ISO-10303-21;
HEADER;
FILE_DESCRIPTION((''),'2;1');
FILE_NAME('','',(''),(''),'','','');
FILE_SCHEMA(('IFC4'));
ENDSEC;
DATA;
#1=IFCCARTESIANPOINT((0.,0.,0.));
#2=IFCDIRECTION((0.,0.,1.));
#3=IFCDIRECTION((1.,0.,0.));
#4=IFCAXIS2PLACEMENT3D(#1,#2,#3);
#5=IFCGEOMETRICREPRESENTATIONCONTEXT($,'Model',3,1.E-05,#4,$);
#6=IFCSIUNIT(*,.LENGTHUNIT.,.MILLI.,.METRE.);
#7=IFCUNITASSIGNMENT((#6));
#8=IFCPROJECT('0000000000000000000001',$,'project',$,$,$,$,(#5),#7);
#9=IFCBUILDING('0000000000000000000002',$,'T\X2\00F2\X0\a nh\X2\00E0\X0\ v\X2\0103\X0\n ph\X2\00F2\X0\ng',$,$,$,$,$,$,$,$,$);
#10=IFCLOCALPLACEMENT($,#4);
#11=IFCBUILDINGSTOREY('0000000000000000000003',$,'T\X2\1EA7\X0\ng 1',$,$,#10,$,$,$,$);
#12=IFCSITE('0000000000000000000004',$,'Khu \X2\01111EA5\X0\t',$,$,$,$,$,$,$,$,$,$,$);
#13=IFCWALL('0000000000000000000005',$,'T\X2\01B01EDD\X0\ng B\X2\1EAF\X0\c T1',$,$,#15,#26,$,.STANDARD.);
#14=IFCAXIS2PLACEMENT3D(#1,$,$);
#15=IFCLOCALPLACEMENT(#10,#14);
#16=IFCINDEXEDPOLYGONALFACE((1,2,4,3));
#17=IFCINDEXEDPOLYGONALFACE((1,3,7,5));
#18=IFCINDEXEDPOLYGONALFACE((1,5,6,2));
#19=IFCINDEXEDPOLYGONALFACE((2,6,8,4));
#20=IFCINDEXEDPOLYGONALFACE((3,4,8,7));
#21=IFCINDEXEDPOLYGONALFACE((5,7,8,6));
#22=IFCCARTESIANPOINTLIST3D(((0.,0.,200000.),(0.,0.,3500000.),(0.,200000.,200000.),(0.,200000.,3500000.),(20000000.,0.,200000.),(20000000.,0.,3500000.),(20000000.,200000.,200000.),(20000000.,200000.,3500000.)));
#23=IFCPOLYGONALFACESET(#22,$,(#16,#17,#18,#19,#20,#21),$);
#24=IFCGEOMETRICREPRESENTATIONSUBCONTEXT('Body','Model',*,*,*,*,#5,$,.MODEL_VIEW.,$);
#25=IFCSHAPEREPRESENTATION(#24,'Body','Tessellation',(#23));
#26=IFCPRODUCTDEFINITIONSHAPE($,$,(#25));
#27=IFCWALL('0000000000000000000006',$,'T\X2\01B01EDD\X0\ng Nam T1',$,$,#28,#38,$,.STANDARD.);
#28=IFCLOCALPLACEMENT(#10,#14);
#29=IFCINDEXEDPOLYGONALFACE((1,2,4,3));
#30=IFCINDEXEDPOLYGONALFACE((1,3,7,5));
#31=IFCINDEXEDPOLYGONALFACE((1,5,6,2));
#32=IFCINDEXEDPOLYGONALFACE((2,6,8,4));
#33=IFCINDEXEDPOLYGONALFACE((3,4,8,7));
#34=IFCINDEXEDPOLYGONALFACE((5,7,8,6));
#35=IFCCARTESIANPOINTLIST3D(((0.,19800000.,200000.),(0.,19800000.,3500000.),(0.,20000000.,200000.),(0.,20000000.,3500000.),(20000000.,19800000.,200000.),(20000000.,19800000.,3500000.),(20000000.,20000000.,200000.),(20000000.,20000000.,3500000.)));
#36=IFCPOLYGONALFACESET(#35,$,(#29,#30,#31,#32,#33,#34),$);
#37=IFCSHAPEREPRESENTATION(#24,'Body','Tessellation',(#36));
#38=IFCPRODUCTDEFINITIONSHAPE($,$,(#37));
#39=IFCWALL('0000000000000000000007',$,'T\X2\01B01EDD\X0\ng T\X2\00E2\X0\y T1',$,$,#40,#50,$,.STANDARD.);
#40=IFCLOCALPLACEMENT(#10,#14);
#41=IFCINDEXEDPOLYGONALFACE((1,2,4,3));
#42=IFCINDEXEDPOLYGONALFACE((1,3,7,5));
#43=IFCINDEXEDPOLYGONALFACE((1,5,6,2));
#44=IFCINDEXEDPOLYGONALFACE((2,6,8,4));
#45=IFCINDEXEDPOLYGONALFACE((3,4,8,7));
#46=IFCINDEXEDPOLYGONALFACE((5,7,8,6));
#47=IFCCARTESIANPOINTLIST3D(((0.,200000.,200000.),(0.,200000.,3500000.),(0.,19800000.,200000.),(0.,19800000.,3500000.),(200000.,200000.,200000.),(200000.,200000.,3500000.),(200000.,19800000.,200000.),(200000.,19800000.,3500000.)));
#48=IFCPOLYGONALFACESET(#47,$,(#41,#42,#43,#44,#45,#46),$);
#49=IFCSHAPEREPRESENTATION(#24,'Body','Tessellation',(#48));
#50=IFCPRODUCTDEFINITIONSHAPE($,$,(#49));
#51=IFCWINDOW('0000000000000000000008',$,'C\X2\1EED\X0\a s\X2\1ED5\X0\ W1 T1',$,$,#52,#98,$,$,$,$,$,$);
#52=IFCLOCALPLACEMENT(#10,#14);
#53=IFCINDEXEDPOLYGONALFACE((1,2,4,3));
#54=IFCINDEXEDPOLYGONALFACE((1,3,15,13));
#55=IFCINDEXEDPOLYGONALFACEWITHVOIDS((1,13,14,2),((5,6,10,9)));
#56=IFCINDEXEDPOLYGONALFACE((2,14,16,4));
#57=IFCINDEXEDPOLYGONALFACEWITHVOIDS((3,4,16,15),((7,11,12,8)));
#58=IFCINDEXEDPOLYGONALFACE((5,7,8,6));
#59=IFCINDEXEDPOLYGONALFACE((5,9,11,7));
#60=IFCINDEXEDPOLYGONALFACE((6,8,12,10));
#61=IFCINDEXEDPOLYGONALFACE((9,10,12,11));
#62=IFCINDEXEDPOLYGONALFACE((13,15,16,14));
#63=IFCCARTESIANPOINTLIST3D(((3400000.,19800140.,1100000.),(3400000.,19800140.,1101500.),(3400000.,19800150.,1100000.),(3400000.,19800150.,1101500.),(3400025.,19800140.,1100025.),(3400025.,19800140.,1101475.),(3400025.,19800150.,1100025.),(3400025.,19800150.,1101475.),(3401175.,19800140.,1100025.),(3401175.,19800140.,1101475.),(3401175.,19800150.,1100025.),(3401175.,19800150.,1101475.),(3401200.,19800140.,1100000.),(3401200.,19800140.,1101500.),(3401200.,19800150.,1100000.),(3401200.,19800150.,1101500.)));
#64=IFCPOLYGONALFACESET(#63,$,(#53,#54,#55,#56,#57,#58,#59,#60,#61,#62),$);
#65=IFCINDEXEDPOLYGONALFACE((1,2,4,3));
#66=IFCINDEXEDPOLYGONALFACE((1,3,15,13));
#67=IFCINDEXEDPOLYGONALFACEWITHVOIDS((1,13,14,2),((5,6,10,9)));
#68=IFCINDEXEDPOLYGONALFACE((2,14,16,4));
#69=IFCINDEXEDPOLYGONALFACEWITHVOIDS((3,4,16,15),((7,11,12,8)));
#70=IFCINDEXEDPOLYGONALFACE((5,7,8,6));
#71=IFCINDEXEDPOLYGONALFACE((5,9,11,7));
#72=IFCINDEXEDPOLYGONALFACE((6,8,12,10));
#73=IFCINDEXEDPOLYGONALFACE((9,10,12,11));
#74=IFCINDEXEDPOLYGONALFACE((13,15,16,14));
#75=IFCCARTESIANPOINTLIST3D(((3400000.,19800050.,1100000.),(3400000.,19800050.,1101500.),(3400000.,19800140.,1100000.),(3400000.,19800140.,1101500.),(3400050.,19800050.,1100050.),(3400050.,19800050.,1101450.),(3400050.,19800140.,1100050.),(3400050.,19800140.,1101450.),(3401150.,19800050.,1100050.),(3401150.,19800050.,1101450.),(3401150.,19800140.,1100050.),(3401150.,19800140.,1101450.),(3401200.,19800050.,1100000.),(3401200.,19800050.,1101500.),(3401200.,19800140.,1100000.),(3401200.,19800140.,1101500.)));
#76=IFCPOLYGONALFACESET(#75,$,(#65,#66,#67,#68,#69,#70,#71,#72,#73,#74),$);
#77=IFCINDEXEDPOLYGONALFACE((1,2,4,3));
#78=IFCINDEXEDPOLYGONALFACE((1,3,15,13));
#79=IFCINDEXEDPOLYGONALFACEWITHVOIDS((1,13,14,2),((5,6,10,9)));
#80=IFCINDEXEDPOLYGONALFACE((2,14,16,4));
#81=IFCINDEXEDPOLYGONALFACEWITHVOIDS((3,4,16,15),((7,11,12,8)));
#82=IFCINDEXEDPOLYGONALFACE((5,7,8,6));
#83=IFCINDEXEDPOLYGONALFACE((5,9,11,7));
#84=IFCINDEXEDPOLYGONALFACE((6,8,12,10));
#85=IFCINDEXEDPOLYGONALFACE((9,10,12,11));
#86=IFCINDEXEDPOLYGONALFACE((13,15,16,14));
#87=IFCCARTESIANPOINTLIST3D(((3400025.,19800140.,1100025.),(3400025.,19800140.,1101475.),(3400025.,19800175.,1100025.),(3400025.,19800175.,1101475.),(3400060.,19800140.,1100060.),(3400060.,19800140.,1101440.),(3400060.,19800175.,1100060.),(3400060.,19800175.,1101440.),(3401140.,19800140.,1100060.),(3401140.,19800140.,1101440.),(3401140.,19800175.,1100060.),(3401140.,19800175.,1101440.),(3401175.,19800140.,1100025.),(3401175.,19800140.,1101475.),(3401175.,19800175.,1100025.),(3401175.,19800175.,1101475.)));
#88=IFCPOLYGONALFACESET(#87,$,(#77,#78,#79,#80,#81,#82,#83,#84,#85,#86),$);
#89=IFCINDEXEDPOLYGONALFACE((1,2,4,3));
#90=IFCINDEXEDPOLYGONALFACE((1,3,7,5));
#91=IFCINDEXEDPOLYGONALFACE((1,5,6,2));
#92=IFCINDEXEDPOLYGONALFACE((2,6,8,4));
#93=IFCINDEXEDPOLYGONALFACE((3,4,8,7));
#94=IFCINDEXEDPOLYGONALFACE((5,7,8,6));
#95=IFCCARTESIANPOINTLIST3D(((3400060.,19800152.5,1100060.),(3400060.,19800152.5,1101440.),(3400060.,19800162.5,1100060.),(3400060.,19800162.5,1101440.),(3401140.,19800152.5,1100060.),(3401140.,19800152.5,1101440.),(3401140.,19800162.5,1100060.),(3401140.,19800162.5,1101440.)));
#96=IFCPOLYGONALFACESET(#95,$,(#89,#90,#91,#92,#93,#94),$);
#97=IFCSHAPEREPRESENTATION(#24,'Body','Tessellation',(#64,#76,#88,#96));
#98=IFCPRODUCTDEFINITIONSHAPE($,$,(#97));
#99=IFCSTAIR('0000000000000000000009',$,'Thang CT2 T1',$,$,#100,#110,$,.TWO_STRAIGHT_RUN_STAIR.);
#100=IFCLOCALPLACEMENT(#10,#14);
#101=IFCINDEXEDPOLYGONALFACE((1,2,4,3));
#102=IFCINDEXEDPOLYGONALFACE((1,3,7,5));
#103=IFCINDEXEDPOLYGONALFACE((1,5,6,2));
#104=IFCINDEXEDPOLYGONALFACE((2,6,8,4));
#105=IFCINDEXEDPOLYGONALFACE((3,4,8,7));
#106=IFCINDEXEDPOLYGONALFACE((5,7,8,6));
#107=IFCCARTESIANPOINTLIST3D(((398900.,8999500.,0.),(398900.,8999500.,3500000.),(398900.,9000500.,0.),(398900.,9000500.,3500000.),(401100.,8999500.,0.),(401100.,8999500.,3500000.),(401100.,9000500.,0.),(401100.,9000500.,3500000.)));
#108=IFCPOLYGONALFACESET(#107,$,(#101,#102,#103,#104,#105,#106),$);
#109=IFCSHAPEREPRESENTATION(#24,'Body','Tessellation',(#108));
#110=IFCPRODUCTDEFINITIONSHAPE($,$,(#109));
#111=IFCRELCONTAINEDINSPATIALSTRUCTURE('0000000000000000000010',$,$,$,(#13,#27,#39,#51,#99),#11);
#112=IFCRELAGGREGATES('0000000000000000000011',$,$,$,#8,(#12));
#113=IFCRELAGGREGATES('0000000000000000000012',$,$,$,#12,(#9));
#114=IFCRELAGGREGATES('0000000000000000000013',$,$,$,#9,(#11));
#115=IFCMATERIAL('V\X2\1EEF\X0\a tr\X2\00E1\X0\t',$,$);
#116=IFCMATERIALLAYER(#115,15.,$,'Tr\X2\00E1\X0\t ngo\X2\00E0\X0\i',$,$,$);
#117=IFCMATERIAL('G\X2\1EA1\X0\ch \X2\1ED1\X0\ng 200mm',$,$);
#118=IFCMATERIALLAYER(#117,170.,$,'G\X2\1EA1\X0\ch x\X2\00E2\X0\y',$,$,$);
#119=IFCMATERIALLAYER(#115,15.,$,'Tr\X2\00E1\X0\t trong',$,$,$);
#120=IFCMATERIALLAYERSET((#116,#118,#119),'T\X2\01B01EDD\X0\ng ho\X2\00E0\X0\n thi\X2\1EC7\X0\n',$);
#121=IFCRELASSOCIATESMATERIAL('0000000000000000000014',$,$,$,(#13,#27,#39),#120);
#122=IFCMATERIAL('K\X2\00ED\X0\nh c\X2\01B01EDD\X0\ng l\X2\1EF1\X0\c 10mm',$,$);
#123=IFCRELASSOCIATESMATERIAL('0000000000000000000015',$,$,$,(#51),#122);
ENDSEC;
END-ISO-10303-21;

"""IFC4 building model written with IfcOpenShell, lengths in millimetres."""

from ifc_helpers import new_model, entity, si_unit, frame, origin_with_axes, place, context, subcontext, project, spatial, line, indexed_curve, outline, extrude, material, layer, layer_set, layer_usage, element, save


model = new_model("IFC4")

# Units and contexts
model_context = context("Model", 3, precision=1e-05, world=origin_with_axes())
body_context = subcontext(model_context, "Body", "Model", "MODEL_VIEW")
ifc_project = project(units=[si_unit("LENGTHUNIT", "METRE", prefix="MILLI")], contexts=[model_context])

# Site, building, storey
site = spatial("IfcSite", under=ifc_project, Name="Khu đất")
building = spatial("IfcBuilding", under=site, Name="Tòa nhà văn phòng")
storey_placement = place(None, origin_with_axes())
storey = spatial("IfcBuildingStorey", under=building, at=storey_placement, Name="Tầng 1")

# Walls
ifc_material_1 = material(Name="Vữa trát")
ifc_layer_1 = layer(ifc_material_1, 15.0, Name="Trát ngoài")
ifc_material_2 = material(Name="Gạch ống 200mm")
ifc_layer_2 = layer(ifc_material_2, 170.0, Name="Gạch xây")
ifc_layer_3 = layer(ifc_material_1, 15.0, Name="Trát trong")
ifc_layer_set = layer_set([ifc_layer_1, ifc_layer_2, ifc_layer_3], Name="Tường hoàn thiện")
ifc_layer_usage_1 = layer_usage(ifc_layer_set, "AXIS2", "POSITIVE", 0.0)
wall_1_placement = place(storey_placement, frame((0.0, 0.0, 200000.0), z_axis=(0.0, 0.0, 1.0), x_axis=(1.0, 0.0, 0.0)))
element("IfcWall", 1, at=wall_1_placement, inside=storey, material=ifc_layer_usage_1, Name="Tường Bắc T1", PredefinedType="STANDARD", context=body_context, shape_type="SweptSolid", body=[
    extrude(outline(indexed_curve([(0.0, 0.0), (0.0, 200000.0), (20000000.0, 200000.0), (20000000.0, 0.0), (0.0, 0.0)], self_intersect=False)), origin_with_axes(), (0.0, 0.0, 1.0), 3300000.0),
])
ifc_layer_usage_2 = layer_usage(ifc_layer_set, "AXIS2", "POSITIVE", 0.0)
wall_2_placement = place(storey_placement, frame((0.0, 19800000.0, 200000.0), z_axis=(0.0, 0.0, 1.0), x_axis=(1.0, 0.0, 0.0)))
element("IfcWall", 2, at=wall_2_placement, inside=storey, material=ifc_layer_usage_2, Name="Tường Nam T1", PredefinedType="STANDARD", context=body_context, shape_type="SweptSolid", body=[
    extrude(outline(indexed_curve([(0.0, 0.0), (0.0, 200000.0), (20000000.0, 200000.0), (20000000.0, 0.0), (0.0, 0.0)], self_intersect=False)), origin_with_axes(), (0.0, 0.0, 1.0), 3300000.0),
])
ifc_layer_usage_3 = layer_usage(ifc_layer_set, "AXIS2", "POSITIVE", 0.0)
wall_3_placement = place(storey_placement, frame((0.0, 200000.0, 200000.0), z_axis=(0.0, 0.0, 1.0), x_axis=(1.0, 0.0, 0.0)))
element("IfcWall", 3, at=wall_3_placement, inside=storey, material=ifc_layer_usage_3, Name="Tường Tây T1", PredefinedType="STANDARD", context=body_context, shape_type="SweptSolid", body=[
    extrude(outline(indexed_curve([(0.0, 0.0), (0.0, 19600000.0), (200000.0, 19600000.0), (200000.0, 0.0), (0.0, 0.0)], self_intersect=False)), origin_with_axes(), (0.0, 0.0, 1.0), 3300000.0),
])

# Window
ifc_material_3 = material(Name="Kính cường lực 10mm")
window_placement = place(storey_placement, frame((3400000.0, 19800000.0, 1100000.0), z_axis=(0.0, 0.0, 1.0), x_axis=(1.0, 0.0, 0.0)))
element("IfcWindow", 4, at=window_placement, inside=storey, material=ifc_material_3, Name="Cửa sổ W1 T1", context=body_context, shape_type="SolidModel", body=[
    extrude(outline(indexed_curve([(0.0, 0.0), (1200.0, 0.0), (1200.0, 1500.0), (0.0, 1500.0)], segments=[line(1, 2, 3, 4, 1)]), holes=[indexed_curve([(25.0, 25.0), (1175.0, 25.0), (1175.0, 1475.0), (25.0, 1475.0)], segments=[line(1, 2, 3, 4, 1)])]), frame((0.0, 140.0, 0.0), z_axis=(0.0, -1.0, 0.0), x_axis=(1.0, 0.0, 0.0)), (0.0, 0.0, -1.0), 10.0),
    extrude(outline(indexed_curve([(0.0, 0.0), (1200.0, 0.0), (1200.0, 1500.0), (0.0, 1500.0)], segments=[line(1, 2, 3, 4, 1)]), holes=[indexed_curve([(50.0, 50.0), (1150.0, 50.0), (1150.0, 1450.0), (50.0, 1450.0)], segments=[line(1, 2, 3, 4, 1)])]), frame((0.0, 50.0, 0.0), z_axis=(0.0, -1.0, 0.0), x_axis=(1.0, 0.0, 0.0)), (0.0, 0.0, -1.0), 90.0),
    extrude(outline(indexed_curve([(0.0, 0.0), (1150.0, 0.0), (1150.0, 1450.0), (0.0, 1450.0)], segments=[line(1, 2, 3, 4, 1)]), holes=[indexed_curve([(35.0, 35.0), (1115.0, 35.0), (1115.0, 1415.0), (35.0, 1415.0)], segments=[line(1, 2, 3, 4, 1)])]), frame((25.0, 140.0, 25.0), z_axis=(0.0, -1.0, 0.0), x_axis=(1.0, 0.0, 0.0)), (0.0, 0.0, -1.0), 35.0),
    extrude(outline(indexed_curve([(35.0, 35.0), (1115.0, 35.0), (1115.0, 1415.0), (35.0, 1415.0)], segments=[line(1, 2, 3, 4, 1)])), frame((25.0, 152.5, 25.0), z_axis=(0.0, -1.0, 0.0), x_axis=(1.0, 0.0, 0.0)), (0.0, 0.0, -1.0), 10.0),
])

# Stair
stair_placement = place(storey_placement, frame((400000.0, 9000000.0, 0.0), z_axis=(0.0, 0.0, 1.0), x_axis=(1.0, 0.0, 0.0)))
element("IfcStair", 5, at=stair_placement, inside=storey, Name="Thang CT2 T1", PredefinedType="TWO_STRAIGHT_RUN_STAIR", context=body_context, shape_type="SweptSolid", body=[
    extrude(entity("IfcRectangleProfileDef", None, None, None, 2200.0, 1000.0), origin_with_axes(), (0.0, 0.0, 1.0), 3500000.0),
])

save(model, "model.ifc")
